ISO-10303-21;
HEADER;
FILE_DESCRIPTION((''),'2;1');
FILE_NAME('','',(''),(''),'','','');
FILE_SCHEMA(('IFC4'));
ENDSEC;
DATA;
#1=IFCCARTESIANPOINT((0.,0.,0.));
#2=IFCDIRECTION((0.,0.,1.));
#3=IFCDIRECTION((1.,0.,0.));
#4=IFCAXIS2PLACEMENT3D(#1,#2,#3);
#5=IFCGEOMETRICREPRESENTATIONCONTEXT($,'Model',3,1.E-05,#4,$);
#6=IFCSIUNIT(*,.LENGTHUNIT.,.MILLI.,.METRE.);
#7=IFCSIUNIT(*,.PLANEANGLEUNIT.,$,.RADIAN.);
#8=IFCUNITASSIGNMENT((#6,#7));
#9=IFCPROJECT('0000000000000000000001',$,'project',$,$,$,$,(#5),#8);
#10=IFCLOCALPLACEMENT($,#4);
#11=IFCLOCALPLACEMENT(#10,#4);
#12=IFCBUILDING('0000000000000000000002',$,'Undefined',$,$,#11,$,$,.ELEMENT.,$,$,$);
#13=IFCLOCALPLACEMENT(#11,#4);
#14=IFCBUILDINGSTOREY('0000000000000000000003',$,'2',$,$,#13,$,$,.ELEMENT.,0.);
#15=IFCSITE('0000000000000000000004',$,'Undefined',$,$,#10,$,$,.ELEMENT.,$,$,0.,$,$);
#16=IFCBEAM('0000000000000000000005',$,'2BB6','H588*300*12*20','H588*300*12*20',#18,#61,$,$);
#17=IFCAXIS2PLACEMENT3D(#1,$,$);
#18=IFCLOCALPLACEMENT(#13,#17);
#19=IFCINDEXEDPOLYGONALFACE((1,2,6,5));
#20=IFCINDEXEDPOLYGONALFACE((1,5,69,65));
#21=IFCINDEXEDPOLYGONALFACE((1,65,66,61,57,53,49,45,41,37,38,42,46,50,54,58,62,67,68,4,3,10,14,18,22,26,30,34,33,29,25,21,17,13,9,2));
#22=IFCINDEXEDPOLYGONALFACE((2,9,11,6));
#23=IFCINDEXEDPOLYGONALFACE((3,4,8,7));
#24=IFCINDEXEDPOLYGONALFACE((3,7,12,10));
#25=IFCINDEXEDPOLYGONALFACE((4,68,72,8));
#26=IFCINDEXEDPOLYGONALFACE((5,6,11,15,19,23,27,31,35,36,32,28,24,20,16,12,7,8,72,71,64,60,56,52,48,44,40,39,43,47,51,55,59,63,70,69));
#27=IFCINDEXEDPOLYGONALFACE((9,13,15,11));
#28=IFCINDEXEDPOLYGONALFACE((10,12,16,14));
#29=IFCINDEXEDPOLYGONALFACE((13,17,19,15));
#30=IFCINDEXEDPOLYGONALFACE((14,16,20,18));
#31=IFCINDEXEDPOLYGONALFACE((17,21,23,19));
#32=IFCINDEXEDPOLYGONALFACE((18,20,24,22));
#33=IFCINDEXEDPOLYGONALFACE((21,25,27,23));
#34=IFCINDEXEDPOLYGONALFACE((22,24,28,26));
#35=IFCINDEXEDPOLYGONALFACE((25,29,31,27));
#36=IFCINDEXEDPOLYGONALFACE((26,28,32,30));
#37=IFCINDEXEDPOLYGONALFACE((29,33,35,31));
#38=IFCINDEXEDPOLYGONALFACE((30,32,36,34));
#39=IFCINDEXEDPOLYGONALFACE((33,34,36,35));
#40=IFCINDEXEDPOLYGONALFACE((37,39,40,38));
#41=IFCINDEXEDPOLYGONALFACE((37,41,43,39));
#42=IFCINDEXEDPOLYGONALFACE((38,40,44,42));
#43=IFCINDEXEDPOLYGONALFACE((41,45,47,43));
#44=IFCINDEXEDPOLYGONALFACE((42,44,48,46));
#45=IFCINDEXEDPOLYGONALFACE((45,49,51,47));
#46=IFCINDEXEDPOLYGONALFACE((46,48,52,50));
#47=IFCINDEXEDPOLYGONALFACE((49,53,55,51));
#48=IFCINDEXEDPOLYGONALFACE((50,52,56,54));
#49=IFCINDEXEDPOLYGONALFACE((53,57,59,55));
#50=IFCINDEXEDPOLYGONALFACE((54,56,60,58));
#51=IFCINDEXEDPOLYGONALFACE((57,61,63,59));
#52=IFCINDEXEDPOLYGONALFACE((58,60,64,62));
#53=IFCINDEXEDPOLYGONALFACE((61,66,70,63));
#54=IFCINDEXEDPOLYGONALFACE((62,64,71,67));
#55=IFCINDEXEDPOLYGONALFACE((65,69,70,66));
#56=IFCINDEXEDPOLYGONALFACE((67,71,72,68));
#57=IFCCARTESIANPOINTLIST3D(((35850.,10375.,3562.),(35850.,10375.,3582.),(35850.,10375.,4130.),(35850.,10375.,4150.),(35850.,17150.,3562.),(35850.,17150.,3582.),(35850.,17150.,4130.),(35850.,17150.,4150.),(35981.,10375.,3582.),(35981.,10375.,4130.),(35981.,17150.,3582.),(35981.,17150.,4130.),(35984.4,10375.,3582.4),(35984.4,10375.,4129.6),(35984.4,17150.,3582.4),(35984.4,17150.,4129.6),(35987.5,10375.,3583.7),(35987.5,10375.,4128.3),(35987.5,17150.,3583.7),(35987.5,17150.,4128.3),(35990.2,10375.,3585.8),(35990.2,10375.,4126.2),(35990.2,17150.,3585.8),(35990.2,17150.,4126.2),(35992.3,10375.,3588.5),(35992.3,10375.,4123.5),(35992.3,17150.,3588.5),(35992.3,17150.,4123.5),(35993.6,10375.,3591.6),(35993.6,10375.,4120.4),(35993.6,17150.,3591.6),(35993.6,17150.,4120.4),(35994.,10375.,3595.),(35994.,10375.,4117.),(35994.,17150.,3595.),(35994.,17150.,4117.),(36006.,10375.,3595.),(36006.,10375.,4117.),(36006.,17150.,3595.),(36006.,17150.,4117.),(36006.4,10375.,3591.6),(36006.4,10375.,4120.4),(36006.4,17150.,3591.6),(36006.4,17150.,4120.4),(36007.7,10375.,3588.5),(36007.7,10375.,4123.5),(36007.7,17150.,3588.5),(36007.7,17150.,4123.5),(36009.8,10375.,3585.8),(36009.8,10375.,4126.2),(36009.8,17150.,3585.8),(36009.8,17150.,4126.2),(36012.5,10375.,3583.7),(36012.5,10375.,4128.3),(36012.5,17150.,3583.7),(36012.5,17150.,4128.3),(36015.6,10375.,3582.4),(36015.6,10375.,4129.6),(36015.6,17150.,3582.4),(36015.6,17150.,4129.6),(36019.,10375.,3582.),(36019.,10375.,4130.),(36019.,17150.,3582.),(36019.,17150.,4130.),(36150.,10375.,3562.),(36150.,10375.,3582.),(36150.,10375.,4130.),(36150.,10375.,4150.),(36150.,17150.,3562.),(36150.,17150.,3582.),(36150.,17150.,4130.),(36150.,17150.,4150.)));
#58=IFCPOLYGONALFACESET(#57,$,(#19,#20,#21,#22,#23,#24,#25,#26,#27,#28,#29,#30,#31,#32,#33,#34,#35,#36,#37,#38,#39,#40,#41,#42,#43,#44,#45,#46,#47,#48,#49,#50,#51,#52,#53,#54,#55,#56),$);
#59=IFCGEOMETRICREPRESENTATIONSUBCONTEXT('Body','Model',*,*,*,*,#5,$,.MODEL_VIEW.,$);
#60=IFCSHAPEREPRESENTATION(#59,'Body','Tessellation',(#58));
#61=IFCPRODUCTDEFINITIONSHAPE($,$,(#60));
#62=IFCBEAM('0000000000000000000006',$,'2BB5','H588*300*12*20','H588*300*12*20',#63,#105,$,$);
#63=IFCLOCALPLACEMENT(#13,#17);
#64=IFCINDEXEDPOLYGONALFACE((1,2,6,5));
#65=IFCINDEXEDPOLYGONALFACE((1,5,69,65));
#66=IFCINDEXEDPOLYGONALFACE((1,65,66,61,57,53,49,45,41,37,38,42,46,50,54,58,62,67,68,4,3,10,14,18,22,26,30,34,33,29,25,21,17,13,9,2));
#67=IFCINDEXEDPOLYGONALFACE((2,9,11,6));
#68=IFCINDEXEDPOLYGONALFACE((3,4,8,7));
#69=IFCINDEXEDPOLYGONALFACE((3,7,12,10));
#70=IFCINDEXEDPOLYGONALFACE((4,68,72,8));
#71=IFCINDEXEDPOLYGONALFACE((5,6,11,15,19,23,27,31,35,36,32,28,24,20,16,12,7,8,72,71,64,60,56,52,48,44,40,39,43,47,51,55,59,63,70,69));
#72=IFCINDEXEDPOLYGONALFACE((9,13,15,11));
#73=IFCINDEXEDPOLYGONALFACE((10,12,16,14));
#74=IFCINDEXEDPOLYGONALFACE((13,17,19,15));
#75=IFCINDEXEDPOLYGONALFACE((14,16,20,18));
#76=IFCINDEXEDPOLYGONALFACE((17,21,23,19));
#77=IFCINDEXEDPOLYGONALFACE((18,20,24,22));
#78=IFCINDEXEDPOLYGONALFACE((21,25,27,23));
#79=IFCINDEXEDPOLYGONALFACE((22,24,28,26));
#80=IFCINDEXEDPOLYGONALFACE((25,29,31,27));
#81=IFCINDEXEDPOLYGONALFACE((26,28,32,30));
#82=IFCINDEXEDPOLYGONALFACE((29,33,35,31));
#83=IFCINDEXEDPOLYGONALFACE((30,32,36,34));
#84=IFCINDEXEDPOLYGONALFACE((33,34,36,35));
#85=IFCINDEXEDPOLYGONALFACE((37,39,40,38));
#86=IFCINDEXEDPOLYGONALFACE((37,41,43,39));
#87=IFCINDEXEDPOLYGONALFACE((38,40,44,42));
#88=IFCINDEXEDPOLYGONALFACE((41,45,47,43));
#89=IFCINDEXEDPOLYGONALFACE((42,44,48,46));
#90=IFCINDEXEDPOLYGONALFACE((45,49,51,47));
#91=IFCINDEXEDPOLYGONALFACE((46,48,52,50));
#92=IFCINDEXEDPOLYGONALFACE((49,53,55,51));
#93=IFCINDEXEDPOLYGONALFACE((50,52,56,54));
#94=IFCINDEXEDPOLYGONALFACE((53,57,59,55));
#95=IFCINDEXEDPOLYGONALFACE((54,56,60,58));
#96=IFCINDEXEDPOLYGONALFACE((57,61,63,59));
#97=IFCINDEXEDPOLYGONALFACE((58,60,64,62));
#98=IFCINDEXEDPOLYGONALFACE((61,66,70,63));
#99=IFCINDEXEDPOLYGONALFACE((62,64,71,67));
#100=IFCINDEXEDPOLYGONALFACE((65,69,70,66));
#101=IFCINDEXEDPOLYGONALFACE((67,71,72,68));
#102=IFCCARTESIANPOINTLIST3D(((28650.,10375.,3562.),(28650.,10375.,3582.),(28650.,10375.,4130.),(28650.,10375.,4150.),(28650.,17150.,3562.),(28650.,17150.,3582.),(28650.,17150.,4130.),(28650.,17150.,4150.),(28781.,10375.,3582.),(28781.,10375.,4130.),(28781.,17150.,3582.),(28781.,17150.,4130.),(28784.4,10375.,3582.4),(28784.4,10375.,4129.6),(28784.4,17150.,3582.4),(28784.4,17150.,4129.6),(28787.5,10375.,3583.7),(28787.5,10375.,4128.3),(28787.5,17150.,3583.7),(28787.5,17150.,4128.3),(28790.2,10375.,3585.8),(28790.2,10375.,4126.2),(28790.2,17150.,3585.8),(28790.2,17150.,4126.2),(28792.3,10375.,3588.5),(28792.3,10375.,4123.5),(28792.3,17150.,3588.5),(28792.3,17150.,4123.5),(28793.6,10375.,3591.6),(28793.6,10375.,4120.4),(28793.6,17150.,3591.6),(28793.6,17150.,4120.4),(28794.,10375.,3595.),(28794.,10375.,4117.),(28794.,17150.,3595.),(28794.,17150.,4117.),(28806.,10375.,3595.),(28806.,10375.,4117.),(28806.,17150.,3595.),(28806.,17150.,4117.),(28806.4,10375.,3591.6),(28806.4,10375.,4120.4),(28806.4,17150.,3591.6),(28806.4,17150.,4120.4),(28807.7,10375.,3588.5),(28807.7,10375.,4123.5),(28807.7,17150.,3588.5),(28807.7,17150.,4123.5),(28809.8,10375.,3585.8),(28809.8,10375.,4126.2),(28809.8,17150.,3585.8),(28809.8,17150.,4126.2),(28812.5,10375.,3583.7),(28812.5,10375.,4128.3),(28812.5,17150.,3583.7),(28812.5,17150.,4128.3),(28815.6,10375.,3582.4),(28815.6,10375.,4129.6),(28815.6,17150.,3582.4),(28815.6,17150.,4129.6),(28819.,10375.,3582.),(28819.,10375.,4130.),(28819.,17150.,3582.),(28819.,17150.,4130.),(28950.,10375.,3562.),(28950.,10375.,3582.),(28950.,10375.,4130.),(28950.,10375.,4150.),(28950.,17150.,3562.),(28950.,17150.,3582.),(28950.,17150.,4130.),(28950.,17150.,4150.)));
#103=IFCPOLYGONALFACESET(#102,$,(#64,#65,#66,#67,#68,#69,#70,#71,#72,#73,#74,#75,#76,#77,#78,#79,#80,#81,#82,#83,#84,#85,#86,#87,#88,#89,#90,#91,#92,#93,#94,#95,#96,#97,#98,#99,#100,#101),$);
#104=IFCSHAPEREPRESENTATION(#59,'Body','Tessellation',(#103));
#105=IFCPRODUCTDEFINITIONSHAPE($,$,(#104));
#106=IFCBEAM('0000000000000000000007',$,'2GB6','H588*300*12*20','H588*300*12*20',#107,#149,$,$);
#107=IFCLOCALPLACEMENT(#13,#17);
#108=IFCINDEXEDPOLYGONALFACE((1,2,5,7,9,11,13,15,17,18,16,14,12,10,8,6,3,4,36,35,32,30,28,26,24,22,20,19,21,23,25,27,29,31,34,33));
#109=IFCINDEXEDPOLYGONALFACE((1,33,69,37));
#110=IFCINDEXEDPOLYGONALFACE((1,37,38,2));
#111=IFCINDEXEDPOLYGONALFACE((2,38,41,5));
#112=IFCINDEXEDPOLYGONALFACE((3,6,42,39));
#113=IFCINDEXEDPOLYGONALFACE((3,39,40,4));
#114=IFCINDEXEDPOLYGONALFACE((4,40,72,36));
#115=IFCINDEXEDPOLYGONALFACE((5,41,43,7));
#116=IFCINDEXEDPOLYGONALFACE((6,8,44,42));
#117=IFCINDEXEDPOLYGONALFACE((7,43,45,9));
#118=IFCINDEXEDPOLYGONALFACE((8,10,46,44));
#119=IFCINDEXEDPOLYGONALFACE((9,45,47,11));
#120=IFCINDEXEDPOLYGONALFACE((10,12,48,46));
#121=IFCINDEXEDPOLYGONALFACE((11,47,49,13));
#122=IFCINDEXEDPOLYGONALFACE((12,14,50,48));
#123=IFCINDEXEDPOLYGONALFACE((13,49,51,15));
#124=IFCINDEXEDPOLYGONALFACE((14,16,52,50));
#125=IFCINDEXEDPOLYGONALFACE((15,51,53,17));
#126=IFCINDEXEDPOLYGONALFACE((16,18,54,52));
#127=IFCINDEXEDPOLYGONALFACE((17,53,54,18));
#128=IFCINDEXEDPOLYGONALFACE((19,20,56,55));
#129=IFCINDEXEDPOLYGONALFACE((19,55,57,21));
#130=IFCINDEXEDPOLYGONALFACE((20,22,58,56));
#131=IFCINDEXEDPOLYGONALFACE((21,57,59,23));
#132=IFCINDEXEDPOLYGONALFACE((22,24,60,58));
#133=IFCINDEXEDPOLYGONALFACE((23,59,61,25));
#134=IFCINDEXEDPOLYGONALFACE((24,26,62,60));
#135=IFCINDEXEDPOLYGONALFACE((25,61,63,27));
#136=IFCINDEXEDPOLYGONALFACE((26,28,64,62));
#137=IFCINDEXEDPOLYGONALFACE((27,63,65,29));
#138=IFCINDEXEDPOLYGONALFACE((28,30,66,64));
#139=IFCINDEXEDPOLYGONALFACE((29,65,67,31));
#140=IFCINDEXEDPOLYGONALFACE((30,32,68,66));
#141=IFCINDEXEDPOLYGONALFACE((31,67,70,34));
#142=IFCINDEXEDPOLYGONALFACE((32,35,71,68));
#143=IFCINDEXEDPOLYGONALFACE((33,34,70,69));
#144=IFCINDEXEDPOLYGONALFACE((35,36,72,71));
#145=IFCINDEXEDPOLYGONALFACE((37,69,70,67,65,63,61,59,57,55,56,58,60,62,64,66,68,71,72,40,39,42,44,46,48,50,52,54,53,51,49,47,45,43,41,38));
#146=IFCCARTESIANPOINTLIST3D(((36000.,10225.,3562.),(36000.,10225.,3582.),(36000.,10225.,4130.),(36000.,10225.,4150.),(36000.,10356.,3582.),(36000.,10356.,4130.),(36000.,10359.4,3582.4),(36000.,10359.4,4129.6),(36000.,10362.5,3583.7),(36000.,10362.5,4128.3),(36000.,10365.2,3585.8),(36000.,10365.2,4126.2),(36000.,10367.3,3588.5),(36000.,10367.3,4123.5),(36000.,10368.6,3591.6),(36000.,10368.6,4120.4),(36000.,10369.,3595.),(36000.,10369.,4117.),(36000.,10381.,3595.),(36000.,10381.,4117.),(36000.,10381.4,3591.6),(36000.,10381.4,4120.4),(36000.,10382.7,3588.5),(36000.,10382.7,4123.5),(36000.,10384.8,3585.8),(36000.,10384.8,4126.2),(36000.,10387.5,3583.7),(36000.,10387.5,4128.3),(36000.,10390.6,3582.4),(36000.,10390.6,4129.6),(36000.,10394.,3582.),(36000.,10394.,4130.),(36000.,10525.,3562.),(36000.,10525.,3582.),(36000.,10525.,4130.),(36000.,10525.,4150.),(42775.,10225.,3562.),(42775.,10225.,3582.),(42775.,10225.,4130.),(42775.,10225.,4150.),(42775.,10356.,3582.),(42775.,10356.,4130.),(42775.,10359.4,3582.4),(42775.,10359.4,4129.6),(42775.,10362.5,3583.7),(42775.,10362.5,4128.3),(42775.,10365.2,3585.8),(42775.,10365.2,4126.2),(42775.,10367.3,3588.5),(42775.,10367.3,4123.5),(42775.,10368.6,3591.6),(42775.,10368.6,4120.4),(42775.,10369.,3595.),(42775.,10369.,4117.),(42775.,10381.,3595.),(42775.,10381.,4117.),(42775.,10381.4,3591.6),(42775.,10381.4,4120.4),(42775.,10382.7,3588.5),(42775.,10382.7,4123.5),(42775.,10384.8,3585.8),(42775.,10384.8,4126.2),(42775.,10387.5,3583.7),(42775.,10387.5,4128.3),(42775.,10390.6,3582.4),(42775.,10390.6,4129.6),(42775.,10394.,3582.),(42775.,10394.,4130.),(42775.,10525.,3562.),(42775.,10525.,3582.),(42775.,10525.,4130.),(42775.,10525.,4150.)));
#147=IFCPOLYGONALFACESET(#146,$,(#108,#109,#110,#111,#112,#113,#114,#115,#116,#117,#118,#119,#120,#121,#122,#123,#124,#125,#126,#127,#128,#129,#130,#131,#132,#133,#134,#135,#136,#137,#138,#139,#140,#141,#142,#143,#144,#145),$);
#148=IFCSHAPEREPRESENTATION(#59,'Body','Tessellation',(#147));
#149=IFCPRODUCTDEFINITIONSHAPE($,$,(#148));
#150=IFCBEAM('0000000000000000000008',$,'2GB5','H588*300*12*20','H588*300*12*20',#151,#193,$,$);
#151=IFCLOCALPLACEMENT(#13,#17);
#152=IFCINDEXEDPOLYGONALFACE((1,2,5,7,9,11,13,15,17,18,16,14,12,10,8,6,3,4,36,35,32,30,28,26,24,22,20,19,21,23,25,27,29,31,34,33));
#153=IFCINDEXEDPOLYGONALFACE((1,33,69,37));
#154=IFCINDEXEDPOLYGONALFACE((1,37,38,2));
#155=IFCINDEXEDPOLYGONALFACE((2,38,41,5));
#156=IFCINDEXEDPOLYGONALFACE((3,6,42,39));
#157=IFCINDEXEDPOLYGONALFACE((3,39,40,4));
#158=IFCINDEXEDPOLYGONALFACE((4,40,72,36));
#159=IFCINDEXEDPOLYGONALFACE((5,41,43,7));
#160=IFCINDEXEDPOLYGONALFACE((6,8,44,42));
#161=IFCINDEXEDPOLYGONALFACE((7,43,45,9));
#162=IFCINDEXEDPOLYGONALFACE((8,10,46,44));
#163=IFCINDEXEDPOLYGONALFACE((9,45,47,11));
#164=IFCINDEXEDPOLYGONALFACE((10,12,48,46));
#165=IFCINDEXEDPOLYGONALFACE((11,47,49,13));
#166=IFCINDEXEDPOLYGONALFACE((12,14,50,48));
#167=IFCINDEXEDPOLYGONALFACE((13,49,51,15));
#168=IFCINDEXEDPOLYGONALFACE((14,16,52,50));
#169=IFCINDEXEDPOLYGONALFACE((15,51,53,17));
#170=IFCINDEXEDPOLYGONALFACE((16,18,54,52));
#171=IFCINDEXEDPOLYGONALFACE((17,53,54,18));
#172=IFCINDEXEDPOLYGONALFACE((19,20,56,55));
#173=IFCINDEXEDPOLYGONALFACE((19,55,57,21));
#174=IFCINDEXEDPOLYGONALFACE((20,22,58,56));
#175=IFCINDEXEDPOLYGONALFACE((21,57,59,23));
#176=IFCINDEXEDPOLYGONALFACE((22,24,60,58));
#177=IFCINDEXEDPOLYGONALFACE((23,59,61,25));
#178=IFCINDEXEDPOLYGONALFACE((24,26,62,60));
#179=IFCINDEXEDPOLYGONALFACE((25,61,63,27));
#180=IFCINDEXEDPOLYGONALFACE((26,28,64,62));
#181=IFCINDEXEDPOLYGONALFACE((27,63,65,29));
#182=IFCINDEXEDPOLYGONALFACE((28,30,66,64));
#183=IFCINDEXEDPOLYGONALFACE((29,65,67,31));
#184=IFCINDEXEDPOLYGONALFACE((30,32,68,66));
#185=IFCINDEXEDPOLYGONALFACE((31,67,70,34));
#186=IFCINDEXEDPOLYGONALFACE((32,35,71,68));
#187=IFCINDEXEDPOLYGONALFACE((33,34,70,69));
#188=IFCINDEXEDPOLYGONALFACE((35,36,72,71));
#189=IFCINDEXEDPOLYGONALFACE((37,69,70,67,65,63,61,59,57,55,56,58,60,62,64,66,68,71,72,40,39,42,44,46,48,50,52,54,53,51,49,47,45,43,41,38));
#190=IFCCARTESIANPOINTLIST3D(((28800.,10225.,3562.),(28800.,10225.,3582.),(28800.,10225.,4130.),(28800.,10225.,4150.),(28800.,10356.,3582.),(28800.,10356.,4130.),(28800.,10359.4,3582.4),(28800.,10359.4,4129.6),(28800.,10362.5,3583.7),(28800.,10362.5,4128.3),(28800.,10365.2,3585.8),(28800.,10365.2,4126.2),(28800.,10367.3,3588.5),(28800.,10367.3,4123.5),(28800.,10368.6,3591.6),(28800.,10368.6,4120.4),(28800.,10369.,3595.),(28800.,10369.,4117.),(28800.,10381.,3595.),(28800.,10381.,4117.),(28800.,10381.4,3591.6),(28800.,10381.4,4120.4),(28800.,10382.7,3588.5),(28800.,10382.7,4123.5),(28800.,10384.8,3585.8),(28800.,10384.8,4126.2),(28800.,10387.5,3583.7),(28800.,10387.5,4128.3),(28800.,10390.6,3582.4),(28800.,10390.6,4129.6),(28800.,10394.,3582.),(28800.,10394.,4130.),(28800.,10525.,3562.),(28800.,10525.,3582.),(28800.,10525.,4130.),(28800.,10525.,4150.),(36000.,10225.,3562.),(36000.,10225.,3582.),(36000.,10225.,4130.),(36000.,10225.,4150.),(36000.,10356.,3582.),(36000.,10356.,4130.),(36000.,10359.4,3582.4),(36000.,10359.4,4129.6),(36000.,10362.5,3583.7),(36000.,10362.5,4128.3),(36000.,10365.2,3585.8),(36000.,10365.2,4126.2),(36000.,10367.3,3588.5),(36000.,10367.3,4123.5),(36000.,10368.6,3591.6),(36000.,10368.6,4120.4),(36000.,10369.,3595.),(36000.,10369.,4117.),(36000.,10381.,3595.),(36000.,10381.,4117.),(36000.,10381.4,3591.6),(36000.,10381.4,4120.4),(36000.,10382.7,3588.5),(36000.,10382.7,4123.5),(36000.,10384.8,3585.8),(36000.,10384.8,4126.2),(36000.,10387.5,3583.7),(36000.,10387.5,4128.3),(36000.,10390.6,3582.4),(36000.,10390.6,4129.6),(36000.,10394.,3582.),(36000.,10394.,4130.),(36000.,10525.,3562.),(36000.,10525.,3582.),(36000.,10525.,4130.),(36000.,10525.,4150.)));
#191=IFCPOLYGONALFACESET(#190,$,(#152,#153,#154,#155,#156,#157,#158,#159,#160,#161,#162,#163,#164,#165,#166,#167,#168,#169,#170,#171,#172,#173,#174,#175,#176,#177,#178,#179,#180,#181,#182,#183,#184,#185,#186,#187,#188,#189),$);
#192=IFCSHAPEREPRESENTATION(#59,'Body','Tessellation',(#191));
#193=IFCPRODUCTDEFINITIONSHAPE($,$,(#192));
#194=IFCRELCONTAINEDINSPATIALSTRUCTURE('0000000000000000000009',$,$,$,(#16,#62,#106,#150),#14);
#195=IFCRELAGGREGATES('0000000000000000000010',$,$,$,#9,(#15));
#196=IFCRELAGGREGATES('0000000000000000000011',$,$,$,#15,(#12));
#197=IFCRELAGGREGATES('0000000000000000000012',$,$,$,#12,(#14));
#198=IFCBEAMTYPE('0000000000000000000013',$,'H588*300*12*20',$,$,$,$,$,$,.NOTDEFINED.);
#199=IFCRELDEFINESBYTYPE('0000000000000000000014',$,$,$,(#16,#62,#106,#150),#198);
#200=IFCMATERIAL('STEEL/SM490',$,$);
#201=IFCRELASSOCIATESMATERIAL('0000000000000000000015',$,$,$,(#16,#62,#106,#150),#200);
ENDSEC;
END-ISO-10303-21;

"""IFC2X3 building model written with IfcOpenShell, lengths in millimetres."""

from ifc_helpers import new_model, si_unit, frame, origin_with_axes, origin_2d_with_axis, place, context, subcontext, project, spatial, i_section, extrude, material, type_object, element, save


model = new_model("IFC2X3")

# Units and contexts
model_context = context("Model", 3, precision=1e-05, world=origin_with_axes())
body_context = subcontext(model_context, "Body", "Model", "MODEL_VIEW")
ifc_project = project(units=[si_unit("LENGTHUNIT", "METRE", prefix="MILLI"), si_unit("PLANEANGLEUNIT", "RADIAN")], contexts=[model_context])

# Site, building, storey
site_placement = place(None, origin_with_axes())
site = spatial("IfcSite", under=ifc_project, at=site_placement, Name="Undefined", CompositionType="ELEMENT", RefElevation=0.0)
building_placement = place(site_placement, origin_with_axes())
building = spatial("IfcBuilding", under=site, at=building_placement, Name="Undefined", CompositionType="ELEMENT")
storey_placement = place(building_placement, origin_with_axes())
storey = spatial("IfcBuildingStorey", under=building, at=storey_placement, Name="2", CompositionType="ELEMENT", Elevation=0.0)

# Beams
ifc_material_1 = material(Name="STEEL/SM490")
beam_type_1 = type_object("IfcBeamType", Name="H588*300*12*20", PredefinedType="NOTDEFINED")
for number, where, z_axis, x_axis, name in (
    (1, (36000.0, 10375.0, 3856.0), (0.0, 0.0, 1.0), (0.0, 1.0, 0.0), "2BB6"),
    (2, (28800.0, 10375.0, 3856.0), (0.0, 0.0, 1.0), (0.0, 1.0, 0.0), "2BB5"),
    (3, (36000.0, 10375.0, 3856.0), (0.0, 0.0, 1.0), (1.0, 0.0, 0.0), "2GB6"),
):
    element("IfcBeam", number, at=place(storey_placement, frame(where, z_axis=z_axis, x_axis=x_axis)), inside=storey, type_object=beam_type_1, material=ifc_material_1, Name=name, Description="H588*300*12*20", ObjectType="H588*300*12*20", context=body_context, shape_type="SweptSolid", body=[
        extrude(i_section(OverallWidth=300.0, OverallDepth=588.0, WebThickness=12.0, FlangeThickness=20.0, FilletRadius=13.0, at=origin_2d_with_axis()), frame((6775.0, 0.0, 0.0), z_axis=(-1.0, 0.0, 0.0), x_axis=(0.0, -1.0, 0.0)), (0.0, 0.0, 1.0), 6775.0),
    ])
beam_1_placement = place(storey_placement, frame((28800.0, 10375.0, 3856.0), z_axis=(0.0, 0.0, 1.0), x_axis=(1.0, 0.0, 0.0)))
element("IfcBeam", 4, at=beam_1_placement, inside=storey, type_object=beam_type_1, material=ifc_material_1, Name="2GB5", Description="H588*300*12*20", ObjectType="H588*300*12*20", context=body_context, shape_type="SweptSolid", body=[
    extrude(i_section(OverallWidth=300.0, OverallDepth=588.0, WebThickness=12.0, FlangeThickness=20.0, FilletRadius=13.0, at=origin_2d_with_axis()), frame((7200.0, 0.0, 0.0), z_axis=(-1.0, 0.0, 0.0), x_axis=(0.0, -1.0, 0.0)), (0.0, 0.0, 1.0), 7200.0),
])

save(model, "model.ifc")
